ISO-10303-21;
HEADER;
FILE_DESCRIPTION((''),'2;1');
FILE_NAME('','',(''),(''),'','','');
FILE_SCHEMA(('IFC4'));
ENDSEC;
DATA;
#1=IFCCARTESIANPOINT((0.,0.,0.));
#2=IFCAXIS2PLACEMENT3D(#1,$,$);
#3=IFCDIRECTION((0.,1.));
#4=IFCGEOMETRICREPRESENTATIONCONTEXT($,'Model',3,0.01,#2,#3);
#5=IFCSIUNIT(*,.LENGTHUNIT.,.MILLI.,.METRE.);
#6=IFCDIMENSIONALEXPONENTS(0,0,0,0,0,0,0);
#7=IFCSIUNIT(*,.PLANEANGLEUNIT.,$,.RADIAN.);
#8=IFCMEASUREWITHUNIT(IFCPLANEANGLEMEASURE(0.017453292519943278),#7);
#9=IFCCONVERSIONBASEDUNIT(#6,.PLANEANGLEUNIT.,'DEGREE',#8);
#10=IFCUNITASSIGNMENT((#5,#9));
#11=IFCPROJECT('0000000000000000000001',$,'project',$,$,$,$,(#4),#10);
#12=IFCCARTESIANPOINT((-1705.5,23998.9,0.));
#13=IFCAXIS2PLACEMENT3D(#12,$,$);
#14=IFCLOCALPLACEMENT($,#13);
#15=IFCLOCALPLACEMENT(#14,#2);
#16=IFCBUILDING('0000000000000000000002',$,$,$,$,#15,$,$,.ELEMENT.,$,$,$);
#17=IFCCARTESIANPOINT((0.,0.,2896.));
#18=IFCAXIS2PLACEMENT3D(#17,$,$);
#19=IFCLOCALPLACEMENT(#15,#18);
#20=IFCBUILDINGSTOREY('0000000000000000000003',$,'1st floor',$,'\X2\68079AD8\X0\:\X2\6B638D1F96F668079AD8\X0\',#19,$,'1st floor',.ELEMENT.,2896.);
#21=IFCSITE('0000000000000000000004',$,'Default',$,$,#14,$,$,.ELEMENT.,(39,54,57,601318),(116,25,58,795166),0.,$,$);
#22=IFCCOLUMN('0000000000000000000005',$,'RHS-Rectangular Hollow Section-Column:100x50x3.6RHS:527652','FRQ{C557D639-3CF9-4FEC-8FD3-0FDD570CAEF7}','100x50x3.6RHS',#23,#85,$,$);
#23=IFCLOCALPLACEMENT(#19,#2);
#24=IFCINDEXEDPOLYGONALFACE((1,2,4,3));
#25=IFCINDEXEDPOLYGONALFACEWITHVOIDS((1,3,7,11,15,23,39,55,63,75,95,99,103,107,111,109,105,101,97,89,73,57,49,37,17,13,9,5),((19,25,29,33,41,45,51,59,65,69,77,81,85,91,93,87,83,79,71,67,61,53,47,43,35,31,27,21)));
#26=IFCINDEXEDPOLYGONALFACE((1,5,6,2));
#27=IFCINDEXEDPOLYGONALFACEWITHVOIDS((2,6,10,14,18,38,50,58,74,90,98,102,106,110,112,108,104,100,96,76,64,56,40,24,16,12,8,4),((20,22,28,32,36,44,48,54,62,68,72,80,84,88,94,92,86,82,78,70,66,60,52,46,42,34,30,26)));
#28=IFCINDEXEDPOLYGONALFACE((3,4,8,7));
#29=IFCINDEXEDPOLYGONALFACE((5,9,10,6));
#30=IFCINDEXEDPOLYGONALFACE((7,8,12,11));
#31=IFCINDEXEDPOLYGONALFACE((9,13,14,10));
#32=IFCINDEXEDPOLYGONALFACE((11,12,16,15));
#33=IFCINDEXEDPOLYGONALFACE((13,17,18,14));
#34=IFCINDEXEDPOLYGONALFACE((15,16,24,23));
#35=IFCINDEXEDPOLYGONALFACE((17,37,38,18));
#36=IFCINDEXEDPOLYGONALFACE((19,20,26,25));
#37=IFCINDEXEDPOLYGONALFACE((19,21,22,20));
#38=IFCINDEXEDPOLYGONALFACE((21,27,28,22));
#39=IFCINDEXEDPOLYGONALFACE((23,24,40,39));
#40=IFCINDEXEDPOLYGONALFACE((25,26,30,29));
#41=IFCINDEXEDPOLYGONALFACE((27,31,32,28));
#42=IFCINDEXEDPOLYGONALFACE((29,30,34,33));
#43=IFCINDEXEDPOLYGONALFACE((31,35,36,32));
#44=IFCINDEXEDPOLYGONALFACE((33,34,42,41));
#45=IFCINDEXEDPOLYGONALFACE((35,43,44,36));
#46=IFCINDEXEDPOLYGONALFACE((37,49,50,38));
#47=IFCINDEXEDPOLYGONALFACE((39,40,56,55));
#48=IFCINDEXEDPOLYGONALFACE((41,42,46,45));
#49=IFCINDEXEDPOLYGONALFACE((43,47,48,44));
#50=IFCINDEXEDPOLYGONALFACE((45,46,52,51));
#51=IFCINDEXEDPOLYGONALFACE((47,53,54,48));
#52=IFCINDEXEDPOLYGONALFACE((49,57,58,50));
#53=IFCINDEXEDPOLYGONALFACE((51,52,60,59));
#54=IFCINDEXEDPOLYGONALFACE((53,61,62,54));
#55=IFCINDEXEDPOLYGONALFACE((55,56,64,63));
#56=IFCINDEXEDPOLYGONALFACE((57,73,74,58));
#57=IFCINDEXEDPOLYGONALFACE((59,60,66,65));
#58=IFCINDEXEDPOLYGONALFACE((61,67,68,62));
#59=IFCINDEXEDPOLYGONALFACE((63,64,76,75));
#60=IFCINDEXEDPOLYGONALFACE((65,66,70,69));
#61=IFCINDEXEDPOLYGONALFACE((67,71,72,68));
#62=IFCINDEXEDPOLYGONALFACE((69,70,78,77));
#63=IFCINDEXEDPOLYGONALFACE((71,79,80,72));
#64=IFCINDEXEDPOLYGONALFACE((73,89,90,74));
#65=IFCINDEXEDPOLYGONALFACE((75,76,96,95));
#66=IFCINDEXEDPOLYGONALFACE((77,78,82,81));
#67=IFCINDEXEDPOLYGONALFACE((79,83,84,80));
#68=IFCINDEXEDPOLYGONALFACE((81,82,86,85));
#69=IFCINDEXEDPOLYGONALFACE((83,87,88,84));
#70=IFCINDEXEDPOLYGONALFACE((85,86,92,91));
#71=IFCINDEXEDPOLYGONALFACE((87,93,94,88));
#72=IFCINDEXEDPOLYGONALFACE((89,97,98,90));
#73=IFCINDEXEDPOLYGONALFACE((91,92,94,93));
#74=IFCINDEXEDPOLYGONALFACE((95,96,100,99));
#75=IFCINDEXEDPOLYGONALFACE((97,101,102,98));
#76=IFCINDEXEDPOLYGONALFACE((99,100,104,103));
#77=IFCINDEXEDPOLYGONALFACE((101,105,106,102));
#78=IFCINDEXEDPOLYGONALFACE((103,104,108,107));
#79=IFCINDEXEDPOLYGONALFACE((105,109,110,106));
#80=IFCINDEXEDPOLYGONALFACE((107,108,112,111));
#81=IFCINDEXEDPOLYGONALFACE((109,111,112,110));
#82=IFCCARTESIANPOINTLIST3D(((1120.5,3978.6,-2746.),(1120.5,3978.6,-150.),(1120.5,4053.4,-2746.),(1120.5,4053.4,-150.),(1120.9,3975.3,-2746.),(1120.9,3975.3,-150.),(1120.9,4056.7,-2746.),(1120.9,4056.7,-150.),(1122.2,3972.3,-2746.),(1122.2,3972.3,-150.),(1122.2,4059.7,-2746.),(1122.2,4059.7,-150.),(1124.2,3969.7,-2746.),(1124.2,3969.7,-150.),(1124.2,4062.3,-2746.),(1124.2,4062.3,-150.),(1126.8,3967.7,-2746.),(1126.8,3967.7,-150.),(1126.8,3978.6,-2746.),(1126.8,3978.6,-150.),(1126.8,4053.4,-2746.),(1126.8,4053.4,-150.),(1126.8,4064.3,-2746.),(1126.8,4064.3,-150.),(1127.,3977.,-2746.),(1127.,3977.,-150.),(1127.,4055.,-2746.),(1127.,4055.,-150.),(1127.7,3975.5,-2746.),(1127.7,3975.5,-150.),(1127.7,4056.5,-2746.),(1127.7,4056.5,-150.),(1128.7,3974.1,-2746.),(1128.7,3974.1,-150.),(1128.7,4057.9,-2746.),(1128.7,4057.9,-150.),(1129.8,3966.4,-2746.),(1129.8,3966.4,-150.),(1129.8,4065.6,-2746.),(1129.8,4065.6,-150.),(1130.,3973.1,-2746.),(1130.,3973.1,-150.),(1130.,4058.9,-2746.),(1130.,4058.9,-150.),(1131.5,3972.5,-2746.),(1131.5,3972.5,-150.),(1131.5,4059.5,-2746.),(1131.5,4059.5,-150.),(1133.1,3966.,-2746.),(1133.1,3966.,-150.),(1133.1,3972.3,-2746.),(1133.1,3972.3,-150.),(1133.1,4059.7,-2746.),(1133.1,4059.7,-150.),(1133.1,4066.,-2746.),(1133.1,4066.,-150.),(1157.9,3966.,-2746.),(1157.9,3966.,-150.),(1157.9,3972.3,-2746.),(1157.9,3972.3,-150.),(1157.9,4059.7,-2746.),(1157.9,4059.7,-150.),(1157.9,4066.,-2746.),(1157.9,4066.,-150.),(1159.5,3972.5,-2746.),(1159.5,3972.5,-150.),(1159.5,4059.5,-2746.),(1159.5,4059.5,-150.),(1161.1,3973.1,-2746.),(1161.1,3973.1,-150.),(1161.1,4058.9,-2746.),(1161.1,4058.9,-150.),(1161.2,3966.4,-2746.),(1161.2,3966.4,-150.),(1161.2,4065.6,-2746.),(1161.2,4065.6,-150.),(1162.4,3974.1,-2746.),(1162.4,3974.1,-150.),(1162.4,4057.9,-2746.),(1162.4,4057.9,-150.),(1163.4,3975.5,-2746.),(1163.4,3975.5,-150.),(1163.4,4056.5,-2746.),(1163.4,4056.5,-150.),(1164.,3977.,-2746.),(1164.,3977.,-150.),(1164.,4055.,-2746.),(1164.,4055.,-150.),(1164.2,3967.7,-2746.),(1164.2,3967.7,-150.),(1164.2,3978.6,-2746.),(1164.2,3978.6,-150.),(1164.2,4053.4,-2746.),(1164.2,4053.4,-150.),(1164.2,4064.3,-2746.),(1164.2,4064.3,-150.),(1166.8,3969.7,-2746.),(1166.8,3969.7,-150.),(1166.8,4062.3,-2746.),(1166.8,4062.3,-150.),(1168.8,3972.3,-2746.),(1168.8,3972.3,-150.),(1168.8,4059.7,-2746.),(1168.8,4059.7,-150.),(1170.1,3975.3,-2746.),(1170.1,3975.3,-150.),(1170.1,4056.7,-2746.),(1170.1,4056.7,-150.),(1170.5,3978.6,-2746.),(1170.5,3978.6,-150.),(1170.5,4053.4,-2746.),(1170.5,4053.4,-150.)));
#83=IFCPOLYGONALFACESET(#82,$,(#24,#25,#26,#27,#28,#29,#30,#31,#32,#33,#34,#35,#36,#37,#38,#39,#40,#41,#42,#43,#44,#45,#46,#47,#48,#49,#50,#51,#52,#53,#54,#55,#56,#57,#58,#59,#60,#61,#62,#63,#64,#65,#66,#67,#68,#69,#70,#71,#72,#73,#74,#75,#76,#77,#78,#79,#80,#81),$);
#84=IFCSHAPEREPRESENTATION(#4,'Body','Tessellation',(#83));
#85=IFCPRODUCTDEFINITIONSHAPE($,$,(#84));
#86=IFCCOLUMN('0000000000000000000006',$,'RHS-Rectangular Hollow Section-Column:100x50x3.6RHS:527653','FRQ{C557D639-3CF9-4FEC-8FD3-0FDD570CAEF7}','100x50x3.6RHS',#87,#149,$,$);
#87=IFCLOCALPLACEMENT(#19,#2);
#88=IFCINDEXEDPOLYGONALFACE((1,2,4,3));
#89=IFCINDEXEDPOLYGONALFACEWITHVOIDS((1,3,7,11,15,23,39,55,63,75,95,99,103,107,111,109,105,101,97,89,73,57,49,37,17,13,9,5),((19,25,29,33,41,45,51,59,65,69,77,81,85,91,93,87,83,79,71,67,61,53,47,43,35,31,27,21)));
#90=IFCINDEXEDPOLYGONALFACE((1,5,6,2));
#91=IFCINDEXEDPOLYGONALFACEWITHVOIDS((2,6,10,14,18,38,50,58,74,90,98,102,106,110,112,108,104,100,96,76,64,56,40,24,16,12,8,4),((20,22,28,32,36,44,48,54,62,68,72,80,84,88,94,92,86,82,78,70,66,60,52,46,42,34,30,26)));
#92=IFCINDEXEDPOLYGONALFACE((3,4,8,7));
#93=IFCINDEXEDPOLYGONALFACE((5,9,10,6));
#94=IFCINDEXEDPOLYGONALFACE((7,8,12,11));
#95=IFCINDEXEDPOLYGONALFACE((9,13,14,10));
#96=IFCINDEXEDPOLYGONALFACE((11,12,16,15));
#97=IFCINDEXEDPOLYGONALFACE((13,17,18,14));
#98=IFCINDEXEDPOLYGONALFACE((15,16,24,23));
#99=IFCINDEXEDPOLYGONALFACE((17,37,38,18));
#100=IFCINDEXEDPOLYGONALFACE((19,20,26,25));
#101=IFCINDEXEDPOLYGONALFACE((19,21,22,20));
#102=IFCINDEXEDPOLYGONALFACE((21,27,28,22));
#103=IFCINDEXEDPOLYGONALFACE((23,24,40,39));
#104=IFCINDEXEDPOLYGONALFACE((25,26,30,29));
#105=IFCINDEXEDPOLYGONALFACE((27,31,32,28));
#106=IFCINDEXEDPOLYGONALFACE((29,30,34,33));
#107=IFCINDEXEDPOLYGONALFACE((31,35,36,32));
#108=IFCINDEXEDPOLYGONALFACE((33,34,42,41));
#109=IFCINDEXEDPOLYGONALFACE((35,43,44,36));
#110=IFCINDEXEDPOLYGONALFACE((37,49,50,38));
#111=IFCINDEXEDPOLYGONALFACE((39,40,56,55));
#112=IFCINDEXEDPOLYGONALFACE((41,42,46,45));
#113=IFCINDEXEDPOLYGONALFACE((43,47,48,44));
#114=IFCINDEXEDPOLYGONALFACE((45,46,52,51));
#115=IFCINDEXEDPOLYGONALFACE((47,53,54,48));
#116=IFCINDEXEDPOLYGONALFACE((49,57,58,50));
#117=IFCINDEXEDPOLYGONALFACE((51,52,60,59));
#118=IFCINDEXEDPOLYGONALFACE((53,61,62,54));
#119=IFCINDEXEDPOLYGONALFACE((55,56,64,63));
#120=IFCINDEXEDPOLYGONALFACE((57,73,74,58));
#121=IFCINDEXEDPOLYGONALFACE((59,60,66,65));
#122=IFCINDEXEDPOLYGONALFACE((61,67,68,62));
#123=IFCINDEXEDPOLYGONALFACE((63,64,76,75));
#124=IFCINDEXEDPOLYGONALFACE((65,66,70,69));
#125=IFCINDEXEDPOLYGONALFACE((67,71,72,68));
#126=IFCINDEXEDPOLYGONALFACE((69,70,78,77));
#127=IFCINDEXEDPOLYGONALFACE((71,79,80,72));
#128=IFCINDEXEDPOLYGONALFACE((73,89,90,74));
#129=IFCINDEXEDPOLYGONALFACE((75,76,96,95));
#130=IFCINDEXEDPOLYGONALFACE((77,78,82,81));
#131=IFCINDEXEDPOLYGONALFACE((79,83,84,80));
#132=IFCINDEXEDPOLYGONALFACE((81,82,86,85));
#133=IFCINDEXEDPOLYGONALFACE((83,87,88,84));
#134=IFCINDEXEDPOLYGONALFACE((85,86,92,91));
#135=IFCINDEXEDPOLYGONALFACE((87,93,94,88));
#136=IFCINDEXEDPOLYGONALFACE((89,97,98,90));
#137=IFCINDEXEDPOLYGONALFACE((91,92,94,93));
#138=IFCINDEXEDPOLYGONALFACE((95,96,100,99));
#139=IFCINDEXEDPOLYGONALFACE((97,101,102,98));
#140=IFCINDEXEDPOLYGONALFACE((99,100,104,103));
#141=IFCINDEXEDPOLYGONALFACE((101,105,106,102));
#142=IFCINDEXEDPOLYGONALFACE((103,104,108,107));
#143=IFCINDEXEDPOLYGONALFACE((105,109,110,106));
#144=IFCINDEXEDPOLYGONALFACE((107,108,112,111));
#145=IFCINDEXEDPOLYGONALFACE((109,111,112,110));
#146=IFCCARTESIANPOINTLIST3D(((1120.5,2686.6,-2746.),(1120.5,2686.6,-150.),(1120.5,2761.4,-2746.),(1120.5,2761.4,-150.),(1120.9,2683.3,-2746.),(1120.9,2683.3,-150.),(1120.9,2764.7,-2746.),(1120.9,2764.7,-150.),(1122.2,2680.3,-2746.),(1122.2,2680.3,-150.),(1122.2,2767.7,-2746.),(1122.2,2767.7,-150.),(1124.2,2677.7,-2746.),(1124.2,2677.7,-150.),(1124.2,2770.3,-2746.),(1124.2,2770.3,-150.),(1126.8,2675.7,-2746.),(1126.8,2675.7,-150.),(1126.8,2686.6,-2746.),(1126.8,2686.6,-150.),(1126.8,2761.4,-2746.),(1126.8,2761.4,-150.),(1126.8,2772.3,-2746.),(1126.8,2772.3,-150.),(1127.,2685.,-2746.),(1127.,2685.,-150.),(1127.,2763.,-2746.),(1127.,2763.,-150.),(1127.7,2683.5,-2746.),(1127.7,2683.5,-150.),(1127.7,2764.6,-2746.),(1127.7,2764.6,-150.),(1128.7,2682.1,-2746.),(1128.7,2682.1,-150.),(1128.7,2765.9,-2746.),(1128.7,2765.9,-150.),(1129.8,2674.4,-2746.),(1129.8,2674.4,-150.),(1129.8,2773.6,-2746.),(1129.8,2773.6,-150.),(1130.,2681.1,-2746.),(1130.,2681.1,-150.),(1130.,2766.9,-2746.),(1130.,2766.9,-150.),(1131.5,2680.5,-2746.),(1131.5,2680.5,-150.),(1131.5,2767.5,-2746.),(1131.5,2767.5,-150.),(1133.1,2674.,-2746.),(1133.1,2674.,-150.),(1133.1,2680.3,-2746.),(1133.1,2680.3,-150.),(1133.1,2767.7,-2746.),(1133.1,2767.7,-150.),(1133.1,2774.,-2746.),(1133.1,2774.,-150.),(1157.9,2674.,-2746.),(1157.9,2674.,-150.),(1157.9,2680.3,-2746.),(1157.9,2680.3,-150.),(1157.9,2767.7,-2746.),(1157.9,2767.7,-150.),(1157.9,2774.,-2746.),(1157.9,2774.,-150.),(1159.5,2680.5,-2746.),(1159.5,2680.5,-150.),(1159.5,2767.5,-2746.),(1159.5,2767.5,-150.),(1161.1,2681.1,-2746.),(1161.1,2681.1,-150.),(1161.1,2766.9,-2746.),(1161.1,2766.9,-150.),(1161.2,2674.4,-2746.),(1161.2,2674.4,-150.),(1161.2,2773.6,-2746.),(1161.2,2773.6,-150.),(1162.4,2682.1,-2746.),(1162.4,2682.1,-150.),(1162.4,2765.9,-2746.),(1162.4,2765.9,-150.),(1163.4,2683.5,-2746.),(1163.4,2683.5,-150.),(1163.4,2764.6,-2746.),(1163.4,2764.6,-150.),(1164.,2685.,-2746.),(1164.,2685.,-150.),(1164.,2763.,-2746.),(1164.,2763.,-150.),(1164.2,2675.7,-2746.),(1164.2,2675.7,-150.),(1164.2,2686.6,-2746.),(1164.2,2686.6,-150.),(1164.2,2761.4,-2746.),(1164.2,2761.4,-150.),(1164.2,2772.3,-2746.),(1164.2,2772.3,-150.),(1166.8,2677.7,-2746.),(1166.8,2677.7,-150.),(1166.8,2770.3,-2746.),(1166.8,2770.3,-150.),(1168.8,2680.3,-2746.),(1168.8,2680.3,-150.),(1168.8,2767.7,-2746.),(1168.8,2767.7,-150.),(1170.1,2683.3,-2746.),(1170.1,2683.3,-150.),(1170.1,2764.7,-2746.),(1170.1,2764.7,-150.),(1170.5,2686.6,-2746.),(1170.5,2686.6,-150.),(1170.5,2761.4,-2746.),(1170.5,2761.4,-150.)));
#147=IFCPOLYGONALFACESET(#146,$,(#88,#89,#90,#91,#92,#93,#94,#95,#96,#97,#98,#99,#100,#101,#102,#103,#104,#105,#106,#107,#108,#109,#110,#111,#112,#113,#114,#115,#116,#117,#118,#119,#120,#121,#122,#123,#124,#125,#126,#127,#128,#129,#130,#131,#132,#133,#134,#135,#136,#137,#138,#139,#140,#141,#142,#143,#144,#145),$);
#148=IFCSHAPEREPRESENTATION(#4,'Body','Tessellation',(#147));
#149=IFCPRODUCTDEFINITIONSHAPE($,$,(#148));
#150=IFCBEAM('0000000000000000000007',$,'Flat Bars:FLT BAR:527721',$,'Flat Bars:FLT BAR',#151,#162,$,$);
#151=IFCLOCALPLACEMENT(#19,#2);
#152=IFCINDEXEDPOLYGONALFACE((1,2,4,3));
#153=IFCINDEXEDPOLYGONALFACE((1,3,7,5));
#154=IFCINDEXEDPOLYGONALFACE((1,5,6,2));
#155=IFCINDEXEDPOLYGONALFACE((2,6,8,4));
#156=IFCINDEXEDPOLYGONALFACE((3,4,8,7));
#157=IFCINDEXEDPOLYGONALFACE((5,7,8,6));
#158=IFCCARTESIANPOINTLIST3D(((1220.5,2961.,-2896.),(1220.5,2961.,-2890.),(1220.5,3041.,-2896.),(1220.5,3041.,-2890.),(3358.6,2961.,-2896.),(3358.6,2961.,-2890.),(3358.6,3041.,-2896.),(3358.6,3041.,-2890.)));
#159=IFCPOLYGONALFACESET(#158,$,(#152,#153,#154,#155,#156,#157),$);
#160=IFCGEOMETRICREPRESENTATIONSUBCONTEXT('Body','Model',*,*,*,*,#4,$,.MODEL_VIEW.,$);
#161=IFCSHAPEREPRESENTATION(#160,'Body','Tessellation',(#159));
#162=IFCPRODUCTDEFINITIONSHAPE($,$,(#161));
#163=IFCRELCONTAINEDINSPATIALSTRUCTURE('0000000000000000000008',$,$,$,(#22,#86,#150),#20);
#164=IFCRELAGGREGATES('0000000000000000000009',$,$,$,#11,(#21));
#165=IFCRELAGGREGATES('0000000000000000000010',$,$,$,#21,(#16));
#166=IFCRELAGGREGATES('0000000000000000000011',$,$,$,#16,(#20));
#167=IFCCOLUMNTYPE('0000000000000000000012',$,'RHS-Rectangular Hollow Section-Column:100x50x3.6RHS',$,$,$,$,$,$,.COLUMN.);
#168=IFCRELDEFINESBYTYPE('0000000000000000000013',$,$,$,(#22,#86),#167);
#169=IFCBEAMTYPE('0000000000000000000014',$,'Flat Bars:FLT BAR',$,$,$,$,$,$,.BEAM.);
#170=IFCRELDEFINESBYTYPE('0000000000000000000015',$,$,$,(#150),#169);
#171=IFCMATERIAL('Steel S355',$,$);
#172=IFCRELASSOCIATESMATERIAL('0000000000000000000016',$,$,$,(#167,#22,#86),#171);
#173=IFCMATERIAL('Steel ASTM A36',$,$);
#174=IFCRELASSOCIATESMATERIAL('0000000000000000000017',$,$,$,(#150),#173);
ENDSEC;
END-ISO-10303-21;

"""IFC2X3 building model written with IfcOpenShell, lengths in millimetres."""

from ifc_helpers import new_model, entity, si_unit, converted_unit, point, direction, frame, frame_2d, origin, origin_2d, origin_2d_with_axis, place, context, subcontext, project, spatial, circle_curve, line_curve, trimmed, segment, composite_curve, rectangle, hollow_rectangle, outline, extrude, clip, halfspace, material, type_object, element, save


model = new_model("IFC2X3")

# Units and contexts
model_context = context("Model", 3, precision=0.01, world=origin(), true_north=direction((0.0, 1.0)))
body_context = subcontext(model_context, "Body", "Model", "MODEL_VIEW")
ifc_project = project(units=[si_unit("LENGTHUNIT", "METRE", prefix="MILLI"), converted_unit("PLANEANGLEUNIT", "DEGREE", entity("IfcPlaneAngleMeasure", 0.017453292519943278), si_unit("PLANEANGLEUNIT", "RADIAN"), dimensions=[0, 0, 0, 0, 0, 0, 0])], contexts=[model_context])

# Site, building, storey
site_placement = place(None, frame((-1705.5, 23998.9, 0.0)))
site = spatial("IfcSite", under=ifc_project, at=site_placement, Name="Default", CompositionType="ELEMENT", RefLatitude=(39, 54, 57, 601318), RefLongitude=(116, 25, 58, 795166), RefElevation=0.0)
building_placement = place(site_placement, origin())
building = spatial("IfcBuilding", under=site, at=building_placement, CompositionType="ELEMENT")
storey_placement = place(building_placement, frame((0.0, 0.0, 2896.0)))
storey = spatial("IfcBuildingStorey", under=building, at=storey_placement, Name="1st floor", ObjectType="标高:正负零标高", LongName="1st floor", CompositionType="ELEMENT", Elevation=2896.0)

# Shared definitions
ifc_material_1 = material(Name="Steel S355")

# Columns, openings
column_type_1 = type_object("IfcColumnType", Name="RHS-Rectangular Hollow Section-Column:100x50x3.6RHS", PredefinedType="COLUMN", material=ifc_material_1)
column_1_placement = place(storey_placement, frame((1145.5, 4016.0, -19.1)))
column_1 = element("IfcColumn", 1, at=column_1_placement, inside=storey, type_object=column_type_1, material=ifc_material_1, Name="RHS-Rectangular Hollow Section-Column:100x50x3.6RHS:527652", Description="FRQ{C557D639-3CF9-4FEC-8FD3-0FDD570CAEF7}", ObjectType="100x50x3.6RHS", context=model_context, shape_type="Clipping", body=[
    clip(clip(extrude(hollow_rectangle(XDim=50.0, YDim=100.0, WallThickness=6.3, InnerFilletRadius=6.3, OuterFilletRadius=12.6, at=origin_2d()), origin(), (0.0, 0.0, -1.0), 2782.8), halfspace(frame((-1145.5, -4016.0, -55.9), z_axis=(0.0, 0.0, -1.0), x_axis=(-1.0, 0.0, 0.0)), True)), halfspace(frame((-1145.5, -4016.0, -2726.9), z_axis=(0.0, 0.0, 1.0), x_axis=(1.0, 0.0, 0.0)), True)),
])
opening_1_placement = place(column_1_placement, frame((0.0, -150.1, -130.9), z_axis=(0.0, 1.0, 0.0), x_axis=(-1.0, 0.0, 0.0)))
element("IfcOpeningElement", 2, at=opening_1_placement, cuts=column_1, ObjectType="Opening", context=model_context, shape_type="SweptSolid", body=[
    extrude(outline(composite_curve([segment(trimmed(circle_curve(frame_2d((43.0, 32.0), x_axis=(1.0, 0.0)), 32.0), [point((43.0, 0.0))], [point((75.0, 32.0))], True, "CARTESIAN"), True, "CONTINUOUS"), segment(trimmed(line_curve((75.0, 32.0), (0.0, 1.0), 86.0), [point((75.0, 32.0))], [point((75.0, 118.0))], True, "CARTESIAN"), True, "CONTINUOUS"), segment(trimmed(circle_curve(frame_2d((43.0, 118.0), x_axis=(1.0, 0.0)), 32.0), [point((75.0, 118.0))], [point((43.0, 150.0))], True, "CARTESIAN"), True, "CONTINUOUS"), segment(trimmed(line_curve((43.0, 150.0), (-1.0, 0.0), 86.0), [point((43.0, 150.0))], [point((-43.0, 150.0))], True, "CARTESIAN"), True, "CONTINUOUS"), segment(trimmed(circle_curve(frame_2d((-43.0, 118.0), x_axis=(1.0, 0.0)), 32.0), [point((-43.0, 150.0))], [point((-75.0, 118.0))], True, "CARTESIAN"), True, "CONTINUOUS"), segment(trimmed(line_curve((-75.0, 118.0), (0.0, -1.0), 86.0), [point((-75.0, 118.0))], [point((-75.0, 32.0))], True, "CARTESIAN"), True, "CONTINUOUS"), segment(trimmed(circle_curve(frame_2d((-43.0, 32.0), x_axis=(1.0, 0.0)), 32.0), [point((-75.0, 32.0))], [point((-43.0, 0.0))], True, "CARTESIAN"), True, "CONTINUOUS"), segment(trimmed(line_curve((-43.0, 0.0), (1.0, 0.0), 86.0), [point((-43.0, 0.0))], [point((43.0, 0.0))], True, "CARTESIAN"), True, "CONTINUOUS")], self_intersect="UNKNOWN")), origin(), (0.0, 0.0, 1.0), 300.2),
])
column_2_placement = place(storey_placement, frame((1145.5, 2724.0, -19.1)))
column_2 = element("IfcColumn", 3, at=column_2_placement, inside=storey, type_object=column_type_1, material=ifc_material_1, Name="RHS-Rectangular Hollow Section-Column:100x50x3.6RHS:527653", Description="FRQ{C557D639-3CF9-4FEC-8FD3-0FDD570CAEF7}", ObjectType="100x50x3.6RHS", context=model_context, shape_type="Clipping", body=[
    clip(clip(extrude(hollow_rectangle(XDim=50.0, YDim=100.0, WallThickness=6.3, InnerFilletRadius=6.3, OuterFilletRadius=12.6, at=origin_2d()), origin(), (0.0, 0.0, -1.0), 2782.8), halfspace(frame((-1145.5, -2724.0, -2726.9), z_axis=(0.0, 0.0, 1.0), x_axis=(1.0, 0.0, 0.0)), True)), halfspace(frame((-1145.5, -2724.0, -55.9), z_axis=(0.0, 0.0, -1.0), x_axis=(-1.0, 0.0, 0.0)), True)),
])
opening_2_placement = place(column_2_placement, frame((0.0, -150.1, -130.9), z_axis=(0.0, 1.0, 0.0), x_axis=(-1.0, 0.0, 0.0)))
element("IfcOpeningElement", 4, at=opening_2_placement, cuts=column_2, ObjectType="Opening", context=model_context, shape_type="SweptSolid", body=[
    extrude(outline(composite_curve([segment(trimmed(circle_curve(frame_2d((43.0, 32.0), x_axis=(1.0, 0.0)), 32.0), [point((43.0, 0.0))], [point((75.0, 32.0))], True, "CARTESIAN"), True, "CONTINUOUS"), segment(trimmed(line_curve((75.0, 32.0), (0.0, 1.0), 86.0), [point((75.0, 32.0))], [point((75.0, 118.0))], True, "CARTESIAN"), True, "CONTINUOUS"), segment(trimmed(circle_curve(frame_2d((43.0, 118.0), x_axis=(1.0, 0.0)), 32.0), [point((75.0, 118.0))], [point((43.0, 150.0))], True, "CARTESIAN"), True, "CONTINUOUS"), segment(trimmed(line_curve((43.0, 150.0), (-1.0, 0.0), 86.0), [point((43.0, 150.0))], [point((-43.0, 150.0))], True, "CARTESIAN"), True, "CONTINUOUS"), segment(trimmed(circle_curve(frame_2d((-43.0, 118.0), x_axis=(1.0, 0.0)), 32.0), [point((-43.0, 150.0))], [point((-75.0, 118.0))], True, "CARTESIAN"), True, "CONTINUOUS"), segment(trimmed(line_curve((-75.0, 118.0), (0.0, -1.0), 86.0), [point((-75.0, 118.0))], [point((-75.0, 32.0))], True, "CARTESIAN"), True, "CONTINUOUS"), segment(trimmed(circle_curve(frame_2d((-43.0, 32.0), x_axis=(1.0, 0.0)), 32.0), [point((-75.0, 32.0))], [point((-43.0, 0.0))], True, "CARTESIAN"), True, "CONTINUOUS"), segment(trimmed(line_curve((-43.0, 0.0), (1.0, 0.0), 86.0), [point((-43.0, 0.0))], [point((43.0, 0.0))], True, "CARTESIAN"), True, "CONTINUOUS")], self_intersect="UNKNOWN")), origin(), (0.0, 0.0, 1.0), 300.2),
])

# Beam
ifc_material_2 = material(Name="Steel ASTM A36")
beam_type_1 = type_object("IfcBeamType", Name="Flat Bars:FLT BAR", PredefinedType="BEAM")
beam_1_placement = place(storey_placement, frame((1220.5, 3001.0, -2890.0)))
element("IfcBeam", 5, at=beam_1_placement, inside=storey, type_object=beam_type_1, material=ifc_material_2, Name="Flat Bars:FLT BAR:527721", ObjectType="Flat Bars:FLT BAR", context=body_context, shape_type="SweptSolid", body=[
    extrude(rectangle(XDim=6.0, YDim=80.0, at=origin_2d_with_axis()), frame((0.0, 0.0, -3.0), z_axis=(1.0, 0.0, 0.0), x_axis=(0.0, 0.0, -1.0)), (0.0, 0.0, 1.0), 2138.1),
])

save(model, "model.ifc")
